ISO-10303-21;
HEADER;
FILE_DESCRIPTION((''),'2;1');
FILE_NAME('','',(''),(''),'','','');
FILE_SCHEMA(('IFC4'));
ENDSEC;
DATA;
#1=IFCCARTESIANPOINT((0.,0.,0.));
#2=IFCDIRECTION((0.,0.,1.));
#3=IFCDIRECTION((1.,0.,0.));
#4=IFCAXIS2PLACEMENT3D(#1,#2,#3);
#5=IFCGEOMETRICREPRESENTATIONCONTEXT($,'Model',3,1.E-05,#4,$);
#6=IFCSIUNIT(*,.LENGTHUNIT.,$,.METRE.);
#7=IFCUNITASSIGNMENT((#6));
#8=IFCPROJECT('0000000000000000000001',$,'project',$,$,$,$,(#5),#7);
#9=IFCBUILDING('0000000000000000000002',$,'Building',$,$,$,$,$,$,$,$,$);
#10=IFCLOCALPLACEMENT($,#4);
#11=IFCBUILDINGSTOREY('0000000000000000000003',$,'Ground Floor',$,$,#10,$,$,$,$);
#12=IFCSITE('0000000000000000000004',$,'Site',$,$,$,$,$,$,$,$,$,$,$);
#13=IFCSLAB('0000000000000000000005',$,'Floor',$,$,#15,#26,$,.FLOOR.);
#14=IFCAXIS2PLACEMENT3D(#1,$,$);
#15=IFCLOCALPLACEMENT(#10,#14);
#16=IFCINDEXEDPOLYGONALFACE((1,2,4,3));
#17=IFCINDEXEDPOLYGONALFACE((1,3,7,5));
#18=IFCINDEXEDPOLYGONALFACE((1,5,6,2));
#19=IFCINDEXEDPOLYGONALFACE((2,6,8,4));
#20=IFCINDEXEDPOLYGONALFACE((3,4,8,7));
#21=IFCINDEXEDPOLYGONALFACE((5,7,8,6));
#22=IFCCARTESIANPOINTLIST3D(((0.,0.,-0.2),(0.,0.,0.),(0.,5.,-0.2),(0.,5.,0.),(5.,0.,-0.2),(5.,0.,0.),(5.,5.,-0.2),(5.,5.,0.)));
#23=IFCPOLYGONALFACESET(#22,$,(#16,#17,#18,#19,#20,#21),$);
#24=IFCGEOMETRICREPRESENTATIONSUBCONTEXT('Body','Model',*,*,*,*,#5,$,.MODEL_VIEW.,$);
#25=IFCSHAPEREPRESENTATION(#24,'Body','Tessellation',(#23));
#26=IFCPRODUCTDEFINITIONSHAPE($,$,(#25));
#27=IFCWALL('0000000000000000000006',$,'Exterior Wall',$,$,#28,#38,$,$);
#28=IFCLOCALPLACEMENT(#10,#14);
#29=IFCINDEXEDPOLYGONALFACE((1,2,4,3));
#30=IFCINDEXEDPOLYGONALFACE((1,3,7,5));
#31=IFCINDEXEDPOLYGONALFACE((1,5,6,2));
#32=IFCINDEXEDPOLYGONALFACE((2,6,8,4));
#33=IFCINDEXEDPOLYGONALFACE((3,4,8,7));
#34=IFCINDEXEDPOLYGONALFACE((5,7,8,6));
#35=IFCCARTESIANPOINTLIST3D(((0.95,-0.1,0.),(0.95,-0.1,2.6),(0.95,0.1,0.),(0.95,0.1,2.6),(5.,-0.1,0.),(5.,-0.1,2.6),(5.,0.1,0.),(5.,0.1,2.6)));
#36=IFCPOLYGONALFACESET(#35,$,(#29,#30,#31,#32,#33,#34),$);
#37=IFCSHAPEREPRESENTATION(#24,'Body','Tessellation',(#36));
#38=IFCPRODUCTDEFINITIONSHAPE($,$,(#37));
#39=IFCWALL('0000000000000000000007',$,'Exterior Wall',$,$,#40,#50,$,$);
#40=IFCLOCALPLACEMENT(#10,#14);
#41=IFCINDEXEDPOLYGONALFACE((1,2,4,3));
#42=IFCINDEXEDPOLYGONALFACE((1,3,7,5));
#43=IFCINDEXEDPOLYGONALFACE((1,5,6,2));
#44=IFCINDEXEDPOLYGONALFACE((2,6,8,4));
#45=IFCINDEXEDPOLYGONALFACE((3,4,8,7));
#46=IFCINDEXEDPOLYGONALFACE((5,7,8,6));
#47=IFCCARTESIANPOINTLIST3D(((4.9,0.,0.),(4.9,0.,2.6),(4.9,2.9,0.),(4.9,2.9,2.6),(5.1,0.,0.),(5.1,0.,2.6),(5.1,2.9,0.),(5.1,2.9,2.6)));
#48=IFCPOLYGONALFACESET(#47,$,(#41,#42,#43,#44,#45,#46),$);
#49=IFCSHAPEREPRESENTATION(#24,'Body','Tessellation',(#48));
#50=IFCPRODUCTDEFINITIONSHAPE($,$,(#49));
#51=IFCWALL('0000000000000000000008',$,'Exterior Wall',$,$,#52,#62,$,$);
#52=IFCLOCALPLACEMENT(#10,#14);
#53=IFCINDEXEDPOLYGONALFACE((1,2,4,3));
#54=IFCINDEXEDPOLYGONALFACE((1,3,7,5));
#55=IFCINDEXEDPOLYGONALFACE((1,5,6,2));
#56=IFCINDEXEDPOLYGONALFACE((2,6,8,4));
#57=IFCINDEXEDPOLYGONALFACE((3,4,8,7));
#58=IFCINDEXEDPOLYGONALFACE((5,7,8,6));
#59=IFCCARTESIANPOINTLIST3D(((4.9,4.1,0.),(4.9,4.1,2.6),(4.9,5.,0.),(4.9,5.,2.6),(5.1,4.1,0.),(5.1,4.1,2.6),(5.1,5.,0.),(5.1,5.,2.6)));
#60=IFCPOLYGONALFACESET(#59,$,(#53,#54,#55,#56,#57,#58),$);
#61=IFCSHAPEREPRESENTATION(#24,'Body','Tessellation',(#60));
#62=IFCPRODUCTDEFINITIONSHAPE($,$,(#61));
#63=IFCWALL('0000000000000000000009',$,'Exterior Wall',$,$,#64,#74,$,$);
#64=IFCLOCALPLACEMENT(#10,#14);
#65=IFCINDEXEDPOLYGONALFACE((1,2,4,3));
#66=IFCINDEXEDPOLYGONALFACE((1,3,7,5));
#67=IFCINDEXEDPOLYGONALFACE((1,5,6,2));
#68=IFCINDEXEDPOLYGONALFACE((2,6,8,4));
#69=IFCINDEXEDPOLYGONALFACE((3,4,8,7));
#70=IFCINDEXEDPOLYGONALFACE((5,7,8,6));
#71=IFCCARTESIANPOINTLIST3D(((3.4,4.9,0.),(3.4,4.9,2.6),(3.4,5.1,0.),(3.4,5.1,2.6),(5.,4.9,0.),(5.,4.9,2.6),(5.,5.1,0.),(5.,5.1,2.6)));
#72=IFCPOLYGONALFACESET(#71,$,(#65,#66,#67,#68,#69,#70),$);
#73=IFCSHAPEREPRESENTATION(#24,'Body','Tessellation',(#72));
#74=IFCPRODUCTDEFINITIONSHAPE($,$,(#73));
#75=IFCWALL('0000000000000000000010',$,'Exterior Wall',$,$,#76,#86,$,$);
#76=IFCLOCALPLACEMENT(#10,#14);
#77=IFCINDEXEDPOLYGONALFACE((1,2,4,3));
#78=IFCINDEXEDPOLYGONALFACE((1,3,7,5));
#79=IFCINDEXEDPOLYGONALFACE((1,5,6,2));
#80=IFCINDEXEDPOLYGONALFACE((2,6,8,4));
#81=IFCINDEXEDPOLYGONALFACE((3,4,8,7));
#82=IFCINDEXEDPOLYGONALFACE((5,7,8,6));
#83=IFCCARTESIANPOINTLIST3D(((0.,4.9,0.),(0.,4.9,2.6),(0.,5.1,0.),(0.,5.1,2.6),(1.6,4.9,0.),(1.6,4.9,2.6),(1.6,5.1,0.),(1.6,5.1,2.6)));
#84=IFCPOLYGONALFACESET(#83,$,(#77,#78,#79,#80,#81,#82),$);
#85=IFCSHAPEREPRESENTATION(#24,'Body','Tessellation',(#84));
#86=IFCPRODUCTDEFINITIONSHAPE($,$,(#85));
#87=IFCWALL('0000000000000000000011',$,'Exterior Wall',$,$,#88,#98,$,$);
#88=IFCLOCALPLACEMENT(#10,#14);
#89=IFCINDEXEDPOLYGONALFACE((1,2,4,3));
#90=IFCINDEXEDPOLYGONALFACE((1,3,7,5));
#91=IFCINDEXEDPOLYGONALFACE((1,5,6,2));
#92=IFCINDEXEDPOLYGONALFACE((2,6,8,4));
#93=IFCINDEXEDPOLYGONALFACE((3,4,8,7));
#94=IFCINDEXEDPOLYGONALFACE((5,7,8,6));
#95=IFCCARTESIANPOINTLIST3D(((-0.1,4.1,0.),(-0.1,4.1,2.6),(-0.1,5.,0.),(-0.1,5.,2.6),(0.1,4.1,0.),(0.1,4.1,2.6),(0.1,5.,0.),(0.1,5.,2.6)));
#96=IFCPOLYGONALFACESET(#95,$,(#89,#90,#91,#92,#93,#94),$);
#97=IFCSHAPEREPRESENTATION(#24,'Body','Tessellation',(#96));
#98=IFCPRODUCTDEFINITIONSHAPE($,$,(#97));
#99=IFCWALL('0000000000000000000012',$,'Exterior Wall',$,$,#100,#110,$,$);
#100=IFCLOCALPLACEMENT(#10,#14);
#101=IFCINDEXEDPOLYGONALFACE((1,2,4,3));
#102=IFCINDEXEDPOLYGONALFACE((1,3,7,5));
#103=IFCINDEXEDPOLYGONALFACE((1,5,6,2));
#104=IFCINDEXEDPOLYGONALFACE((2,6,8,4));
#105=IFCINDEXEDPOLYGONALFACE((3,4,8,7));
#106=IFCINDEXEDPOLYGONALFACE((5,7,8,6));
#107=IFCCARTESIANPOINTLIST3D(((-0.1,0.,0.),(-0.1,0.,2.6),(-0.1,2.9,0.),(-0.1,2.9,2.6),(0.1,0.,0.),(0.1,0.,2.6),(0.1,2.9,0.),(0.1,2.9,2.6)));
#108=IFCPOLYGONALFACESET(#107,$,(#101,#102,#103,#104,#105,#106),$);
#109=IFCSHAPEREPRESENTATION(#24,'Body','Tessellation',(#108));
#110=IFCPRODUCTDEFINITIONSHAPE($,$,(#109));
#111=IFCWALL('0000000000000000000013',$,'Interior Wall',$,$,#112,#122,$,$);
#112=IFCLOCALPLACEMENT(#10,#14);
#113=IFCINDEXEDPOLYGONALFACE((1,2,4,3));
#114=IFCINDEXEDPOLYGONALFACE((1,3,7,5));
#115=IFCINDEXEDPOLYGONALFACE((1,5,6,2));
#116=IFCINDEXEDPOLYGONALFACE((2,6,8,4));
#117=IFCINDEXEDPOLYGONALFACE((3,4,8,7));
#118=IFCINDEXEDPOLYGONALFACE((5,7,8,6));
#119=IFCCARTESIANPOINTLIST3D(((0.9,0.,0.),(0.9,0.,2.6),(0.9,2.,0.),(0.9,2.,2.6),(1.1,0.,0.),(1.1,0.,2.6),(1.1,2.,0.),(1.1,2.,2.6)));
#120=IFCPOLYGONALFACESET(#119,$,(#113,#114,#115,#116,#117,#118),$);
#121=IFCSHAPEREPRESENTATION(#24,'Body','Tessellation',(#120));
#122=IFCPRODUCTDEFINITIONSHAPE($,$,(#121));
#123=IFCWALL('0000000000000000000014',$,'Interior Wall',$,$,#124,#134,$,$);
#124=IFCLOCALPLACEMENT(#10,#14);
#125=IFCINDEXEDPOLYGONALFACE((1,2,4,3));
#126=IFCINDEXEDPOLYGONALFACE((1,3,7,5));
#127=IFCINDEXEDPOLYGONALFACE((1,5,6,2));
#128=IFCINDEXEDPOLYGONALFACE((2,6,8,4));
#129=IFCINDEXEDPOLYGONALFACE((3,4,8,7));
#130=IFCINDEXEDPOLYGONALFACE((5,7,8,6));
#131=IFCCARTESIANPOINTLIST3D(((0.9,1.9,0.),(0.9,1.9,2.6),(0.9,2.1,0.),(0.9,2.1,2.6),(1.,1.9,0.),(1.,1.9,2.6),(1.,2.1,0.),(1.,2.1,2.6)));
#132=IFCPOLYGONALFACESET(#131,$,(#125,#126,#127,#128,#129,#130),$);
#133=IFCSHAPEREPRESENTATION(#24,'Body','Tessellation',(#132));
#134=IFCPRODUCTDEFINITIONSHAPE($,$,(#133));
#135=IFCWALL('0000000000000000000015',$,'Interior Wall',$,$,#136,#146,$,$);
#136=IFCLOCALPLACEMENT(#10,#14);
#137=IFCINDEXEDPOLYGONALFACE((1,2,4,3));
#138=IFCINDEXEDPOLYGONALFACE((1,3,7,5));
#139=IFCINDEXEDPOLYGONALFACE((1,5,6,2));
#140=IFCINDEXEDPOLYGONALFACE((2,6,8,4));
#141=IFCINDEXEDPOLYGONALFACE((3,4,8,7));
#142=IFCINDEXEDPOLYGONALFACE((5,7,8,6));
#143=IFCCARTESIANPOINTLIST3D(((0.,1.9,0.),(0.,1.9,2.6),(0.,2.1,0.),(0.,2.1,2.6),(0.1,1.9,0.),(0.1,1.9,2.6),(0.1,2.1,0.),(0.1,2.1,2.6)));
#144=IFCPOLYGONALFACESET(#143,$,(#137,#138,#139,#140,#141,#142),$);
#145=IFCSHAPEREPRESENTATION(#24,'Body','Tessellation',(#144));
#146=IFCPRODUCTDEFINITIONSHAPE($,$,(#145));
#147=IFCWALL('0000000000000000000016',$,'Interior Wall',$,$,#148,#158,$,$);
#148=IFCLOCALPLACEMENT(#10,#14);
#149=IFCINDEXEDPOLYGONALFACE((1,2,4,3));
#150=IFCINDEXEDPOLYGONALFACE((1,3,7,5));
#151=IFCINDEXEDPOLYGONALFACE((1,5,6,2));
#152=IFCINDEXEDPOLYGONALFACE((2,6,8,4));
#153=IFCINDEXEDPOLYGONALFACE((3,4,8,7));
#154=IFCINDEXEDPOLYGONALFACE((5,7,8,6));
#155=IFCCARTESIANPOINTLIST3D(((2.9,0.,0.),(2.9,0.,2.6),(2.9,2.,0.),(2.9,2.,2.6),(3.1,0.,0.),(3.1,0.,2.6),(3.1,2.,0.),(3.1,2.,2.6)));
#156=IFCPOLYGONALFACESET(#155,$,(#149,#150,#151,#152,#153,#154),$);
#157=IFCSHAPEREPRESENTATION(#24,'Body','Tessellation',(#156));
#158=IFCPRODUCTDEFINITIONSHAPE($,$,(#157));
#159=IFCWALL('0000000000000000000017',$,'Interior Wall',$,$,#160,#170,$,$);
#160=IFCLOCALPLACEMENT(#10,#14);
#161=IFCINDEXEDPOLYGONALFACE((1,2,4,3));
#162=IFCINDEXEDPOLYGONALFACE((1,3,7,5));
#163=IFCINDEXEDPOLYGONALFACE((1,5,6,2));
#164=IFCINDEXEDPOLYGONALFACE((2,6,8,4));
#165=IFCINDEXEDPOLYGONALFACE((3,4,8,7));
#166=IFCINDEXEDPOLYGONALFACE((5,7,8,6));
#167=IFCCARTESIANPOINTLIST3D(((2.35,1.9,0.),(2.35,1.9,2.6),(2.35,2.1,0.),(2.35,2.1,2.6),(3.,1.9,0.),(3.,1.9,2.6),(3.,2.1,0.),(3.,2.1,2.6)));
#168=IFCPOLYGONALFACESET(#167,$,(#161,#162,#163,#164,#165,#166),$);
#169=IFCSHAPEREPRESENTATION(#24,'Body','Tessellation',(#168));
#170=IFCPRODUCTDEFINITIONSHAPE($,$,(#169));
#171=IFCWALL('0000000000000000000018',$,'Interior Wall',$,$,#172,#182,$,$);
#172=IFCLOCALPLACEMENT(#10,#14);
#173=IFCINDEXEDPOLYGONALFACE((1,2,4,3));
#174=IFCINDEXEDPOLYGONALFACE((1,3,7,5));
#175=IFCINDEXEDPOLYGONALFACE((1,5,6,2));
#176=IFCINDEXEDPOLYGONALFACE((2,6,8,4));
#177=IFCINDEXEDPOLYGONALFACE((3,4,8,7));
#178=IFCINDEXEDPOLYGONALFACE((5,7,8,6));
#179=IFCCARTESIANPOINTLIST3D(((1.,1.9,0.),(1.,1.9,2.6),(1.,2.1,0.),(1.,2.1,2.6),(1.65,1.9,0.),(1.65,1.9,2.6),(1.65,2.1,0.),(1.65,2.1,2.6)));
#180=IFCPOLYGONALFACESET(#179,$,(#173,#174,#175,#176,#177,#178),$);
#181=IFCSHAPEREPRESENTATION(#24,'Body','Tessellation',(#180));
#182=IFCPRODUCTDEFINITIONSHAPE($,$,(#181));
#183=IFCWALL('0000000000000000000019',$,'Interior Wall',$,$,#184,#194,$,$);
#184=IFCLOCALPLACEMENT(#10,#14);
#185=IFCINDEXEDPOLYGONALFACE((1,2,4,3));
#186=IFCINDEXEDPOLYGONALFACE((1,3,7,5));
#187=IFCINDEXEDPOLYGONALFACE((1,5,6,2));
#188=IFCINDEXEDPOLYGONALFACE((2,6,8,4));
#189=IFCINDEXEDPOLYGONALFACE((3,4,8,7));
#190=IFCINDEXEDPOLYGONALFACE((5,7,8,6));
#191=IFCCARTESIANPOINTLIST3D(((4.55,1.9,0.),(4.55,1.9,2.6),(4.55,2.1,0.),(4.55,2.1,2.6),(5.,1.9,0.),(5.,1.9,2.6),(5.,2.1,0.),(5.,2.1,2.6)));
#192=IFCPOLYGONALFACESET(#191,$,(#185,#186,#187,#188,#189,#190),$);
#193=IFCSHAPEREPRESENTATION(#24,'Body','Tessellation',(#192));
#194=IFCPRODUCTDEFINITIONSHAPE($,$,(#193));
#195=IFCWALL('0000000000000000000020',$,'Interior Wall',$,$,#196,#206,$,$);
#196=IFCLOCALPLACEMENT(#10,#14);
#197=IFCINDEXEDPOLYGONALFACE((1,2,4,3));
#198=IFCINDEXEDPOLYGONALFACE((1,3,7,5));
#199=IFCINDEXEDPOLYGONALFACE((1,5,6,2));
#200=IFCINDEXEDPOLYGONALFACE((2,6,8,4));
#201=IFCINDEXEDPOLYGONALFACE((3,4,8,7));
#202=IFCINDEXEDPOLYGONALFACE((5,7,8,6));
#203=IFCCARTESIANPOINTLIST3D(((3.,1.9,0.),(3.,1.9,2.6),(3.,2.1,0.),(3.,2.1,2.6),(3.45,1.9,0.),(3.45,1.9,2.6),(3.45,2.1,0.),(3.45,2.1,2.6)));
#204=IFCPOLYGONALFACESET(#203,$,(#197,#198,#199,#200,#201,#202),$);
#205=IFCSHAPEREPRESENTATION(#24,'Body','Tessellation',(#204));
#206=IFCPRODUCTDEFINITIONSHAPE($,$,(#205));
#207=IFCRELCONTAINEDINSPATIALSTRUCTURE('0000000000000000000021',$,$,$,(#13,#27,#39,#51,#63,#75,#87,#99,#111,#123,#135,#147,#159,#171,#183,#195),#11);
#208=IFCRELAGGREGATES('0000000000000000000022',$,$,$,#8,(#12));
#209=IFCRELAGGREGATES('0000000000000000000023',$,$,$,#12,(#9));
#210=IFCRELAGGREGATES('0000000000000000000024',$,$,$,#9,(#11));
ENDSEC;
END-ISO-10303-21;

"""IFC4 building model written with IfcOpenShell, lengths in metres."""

from ifc_helpers import new_model, si_unit, frame, origin_with_axes, place, context, subcontext, project, spatial, indexed_curve, outline, extrude, element, save


model = new_model("IFC4")

# Units and contexts
model_context = context("Model", 3, precision=1e-05, world=origin_with_axes())
body_context = subcontext(model_context, "Body", "Model", "MODEL_VIEW")
ifc_project = project(units=[si_unit("LENGTHUNIT", "METRE")], contexts=[model_context])

# Site, building, storey
site = spatial("IfcSite", under=ifc_project, Name="Site")
building = spatial("IfcBuilding", under=site, Name="Building")
storey_placement = place(None, origin_with_axes())
storey = spatial("IfcBuildingStorey", under=building, at=storey_placement, Name="Ground Floor")

# Slab
slab_placement = place(storey_placement, frame((0.0, 0.0, -0.2), z_axis=(0.0, 0.0, 1.0), x_axis=(1.0, 0.0, 0.0)))
element("IfcSlab", 1, at=slab_placement, inside=storey, Name="Floor", PredefinedType="FLOOR", context=body_context, shape_type="SweptSolid", body=[
    extrude(outline(indexed_curve([(0.0, 0.0), (5.0, 0.0), (5.0, 5.0), (0.0, 5.0)])), None, (0.0, 0.0, 1.0), 0.2),
])

# Walls
wall_1_placement = place(storey_placement, frame((0.95, 0.0, 0.0), z_axis=(0.0, 0.0, 1.0), x_axis=(1.0, 0.0, 0.0)))
element("IfcWall", 2, at=wall_1_placement, inside=storey, Name="Exterior Wall", context=body_context, shape_type="SweptSolid", body=[
    extrude(outline(indexed_curve([(0.0, 0.0), (0.0, 0.2), (4.05, 0.2), (4.05, 0.0), (0.0, 0.0)], self_intersect=False)), frame((0.0, -0.1, 0.0), z_axis=(0.0, 0.0, 1.0), x_axis=(1.0, 0.0, 0.0)), (0.0, 0.0, 1.0), 2.6),
])
wall_2_placement = place(storey_placement, frame((5.0, 0.0, 0.0), z_axis=(0.0, 0.0, 1.0), x_axis=(0.0, 1.0, 0.0)))
element("IfcWall", 3, at=wall_2_placement, inside=storey, Name="Exterior Wall", context=body_context, shape_type="SweptSolid", body=[
    extrude(outline(indexed_curve([(0.0, 0.0), (0.0, 0.2), (2.9, 0.2), (2.9, 0.0), (0.0, 0.0)], self_intersect=False)), frame((0.0, -0.1, 0.0), z_axis=(0.0, 0.0, 1.0), x_axis=(1.0, 0.0, 0.0)), (0.0, 0.0, 1.0), 2.6),
])
wall_3_placement = place(storey_placement, frame((5.0, 4.1, 0.0), z_axis=(0.0, 0.0, 1.0), x_axis=(0.0, 1.0, 0.0)))
element("IfcWall", 4, at=wall_3_placement, inside=storey, Name="Exterior Wall", context=body_context, shape_type="SweptSolid", body=[
    extrude(outline(indexed_curve([(0.0, 0.0), (0.0, 0.2), (0.9, 0.2), (0.9, 0.0), (0.0, 0.0)], self_intersect=False)), frame((0.0, -0.1, 0.0), z_axis=(0.0, 0.0, 1.0), x_axis=(1.0, 0.0, 0.0)), (0.0, 0.0, 1.0), 2.6),
])
for number, where, z_axis, x_axis, name in (
    (5, (5.0, 5.0, 0.0), (0.0, 0.0, 1.0), (-1.0, 0.0, 0.0), "Exterior Wall"),
    (6, (1.6, 5.0, 0.0), (0.0, 0.0, 1.0), (-1.0, 0.0, 0.0), "Exterior Wall"),
):
    element("IfcWall", number, at=place(storey_placement, frame(where, z_axis=z_axis, x_axis=x_axis)), inside=storey, Name=name, context=body_context, shape_type="SweptSolid", body=[
        extrude(outline(indexed_curve([(0.0, 0.0), (0.0, 0.2), (1.6, 0.2), (1.6, 0.0), (0.0, 0.0)], self_intersect=False)), frame((0.0, -0.1, 0.0), z_axis=(0.0, 0.0, 1.0), x_axis=(1.0, 0.0, 0.0)), (0.0, 0.0, 1.0), 2.6),
    ])
wall_4_placement = place(storey_placement, frame((0.0, 5.0, 0.0), z_axis=(0.0, 0.0, 1.0), x_axis=(0.0, -1.0, 0.0)))
element("IfcWall", 7, at=wall_4_placement, inside=storey, Name="Exterior Wall", context=body_context, shape_type="SweptSolid", body=[
    extrude(outline(indexed_curve([(0.0, 0.0), (0.0, 0.2), (0.9, 0.2), (0.9, 0.0), (0.0, 0.0)], self_intersect=False)), frame((0.0, -0.1, 0.0), z_axis=(0.0, 0.0, 1.0), x_axis=(1.0, 0.0, 0.0)), (0.0, 0.0, 1.0), 2.6),
])
wall_5_placement = place(storey_placement, frame((0.0, 2.9, 0.0), z_axis=(0.0, 0.0, 1.0), x_axis=(0.0, -1.0, 0.0)))
element("IfcWall", 8, at=wall_5_placement, inside=storey, Name="Exterior Wall", context=body_context, shape_type="SweptSolid", body=[
    extrude(outline(indexed_curve([(0.0, 0.0), (0.0, 0.2), (2.9, 0.2), (2.9, 0.0), (0.0, 0.0)], self_intersect=False)), frame((0.0, -0.1, 0.0), z_axis=(0.0, 0.0, 1.0), x_axis=(1.0, 0.0, 0.0)), (0.0, 0.0, 1.0), 2.6),
])
wall_6_placement = place(storey_placement, frame((1.0, 0.0, 0.0), z_axis=(0.0, 0.0, 1.0), x_axis=(0.0, 1.0, 0.0)))
element("IfcWall", 9, at=wall_6_placement, inside=storey, Name="Interior Wall", context=body_context, shape_type="SweptSolid", body=[
    extrude(outline(indexed_curve([(0.0, 0.0), (0.0, 0.2), (2.0, 0.2), (2.0, 0.0), (0.0, 0.0)], self_intersect=False)), frame((0.0, -0.1, 0.0), z_axis=(0.0, 0.0, 1.0), x_axis=(1.0, 0.0, 0.0)), (0.0, 0.0, 1.0), 2.6),
])
for number, where, z_axis, x_axis, name in (
    (10, (1.0, 2.0, 0.0), (0.0, 0.0, 1.0), (-1.0, 0.0, 0.0), "Interior Wall"),
    (11, (0.1, 2.0, 0.0), (0.0, 0.0, 1.0), (-1.0, 0.0, 0.0), "Interior Wall"),
):
    element("IfcWall", number, at=place(storey_placement, frame(where, z_axis=z_axis, x_axis=x_axis)), inside=storey, Name=name, context=body_context, shape_type="SweptSolid", body=[
        extrude(outline(indexed_curve([(0.0, 0.0), (0.0, 0.2), (0.1, 0.2), (0.1, 0.0), (0.0, 0.0)], self_intersect=False)), frame((0.0, -0.1, 0.0), z_axis=(0.0, 0.0, 1.0), x_axis=(1.0, 0.0, 0.0)), (0.0, 0.0, 1.0), 2.6),
    ])
wall_7_placement = place(storey_placement, frame((3.0, 0.0, 0.0), z_axis=(0.0, 0.0, 1.0), x_axis=(0.0, 1.0, 0.0)))
element("IfcWall", 12, at=wall_7_placement, inside=storey, Name="Interior Wall", context=body_context, shape_type="SweptSolid", body=[
    extrude(outline(indexed_curve([(0.0, 0.0), (0.0, 0.2), (2.0, 0.2), (2.0, 0.0), (0.0, 0.0)], self_intersect=False)), frame((0.0, -0.1, 0.0), z_axis=(0.0, 0.0, 1.0), x_axis=(1.0, 0.0, 0.0)), (0.0, 0.0, 1.0), 2.6),
])
for number, where, z_axis, x_axis, name in (
    (13, (3.0, 2.0, 0.0), (0.0, 0.0, 1.0), (-1.0, 0.0, 0.0), "Interior Wall"),
    (14, (1.65, 2.0, 0.0), (0.0, 0.0, 1.0), (-1.0, 0.0, 0.0), "Interior Wall"),
):
    element("IfcWall", number, at=place(storey_placement, frame(where, z_axis=z_axis, x_axis=x_axis)), inside=storey, Name=name, context=body_context, shape_type="SweptSolid", body=[
        extrude(outline(indexed_curve([(0.0, 0.0), (0.0, 0.2), (0.65, 0.2), (0.65, 0.0), (0.0, 0.0)], self_intersect=False)), frame((0.0, -0.1, 0.0), z_axis=(0.0, 0.0, 1.0), x_axis=(1.0, 0.0, 0.0)), (0.0, 0.0, 1.0), 2.6),
    ])
for number, where, z_axis, x_axis, name in (
    (15, (5.0, 2.0, 0.0), (0.0, 0.0, 1.0), (-1.0, 0.0, 0.0), "Interior Wall"),
    (16, (3.45, 2.0, 0.0), (0.0, 0.0, 1.0), (-1.0, 0.0, 0.0), "Interior Wall"),
):
    element("IfcWall", number, at=place(storey_placement, frame(where, z_axis=z_axis, x_axis=x_axis)), inside=storey, Name=name, context=body_context, shape_type="SweptSolid", body=[
        extrude(outline(indexed_curve([(0.0, 0.0), (0.0, 0.2), (0.45, 0.2), (0.45, 0.0), (0.0, 0.0)], self_intersect=False)), frame((0.0, -0.1, 0.0), z_axis=(0.0, 0.0, 1.0), x_axis=(1.0, 0.0, 0.0)), (0.0, 0.0, 1.0), 2.6),
    ])

save(model, "model.ifc")
